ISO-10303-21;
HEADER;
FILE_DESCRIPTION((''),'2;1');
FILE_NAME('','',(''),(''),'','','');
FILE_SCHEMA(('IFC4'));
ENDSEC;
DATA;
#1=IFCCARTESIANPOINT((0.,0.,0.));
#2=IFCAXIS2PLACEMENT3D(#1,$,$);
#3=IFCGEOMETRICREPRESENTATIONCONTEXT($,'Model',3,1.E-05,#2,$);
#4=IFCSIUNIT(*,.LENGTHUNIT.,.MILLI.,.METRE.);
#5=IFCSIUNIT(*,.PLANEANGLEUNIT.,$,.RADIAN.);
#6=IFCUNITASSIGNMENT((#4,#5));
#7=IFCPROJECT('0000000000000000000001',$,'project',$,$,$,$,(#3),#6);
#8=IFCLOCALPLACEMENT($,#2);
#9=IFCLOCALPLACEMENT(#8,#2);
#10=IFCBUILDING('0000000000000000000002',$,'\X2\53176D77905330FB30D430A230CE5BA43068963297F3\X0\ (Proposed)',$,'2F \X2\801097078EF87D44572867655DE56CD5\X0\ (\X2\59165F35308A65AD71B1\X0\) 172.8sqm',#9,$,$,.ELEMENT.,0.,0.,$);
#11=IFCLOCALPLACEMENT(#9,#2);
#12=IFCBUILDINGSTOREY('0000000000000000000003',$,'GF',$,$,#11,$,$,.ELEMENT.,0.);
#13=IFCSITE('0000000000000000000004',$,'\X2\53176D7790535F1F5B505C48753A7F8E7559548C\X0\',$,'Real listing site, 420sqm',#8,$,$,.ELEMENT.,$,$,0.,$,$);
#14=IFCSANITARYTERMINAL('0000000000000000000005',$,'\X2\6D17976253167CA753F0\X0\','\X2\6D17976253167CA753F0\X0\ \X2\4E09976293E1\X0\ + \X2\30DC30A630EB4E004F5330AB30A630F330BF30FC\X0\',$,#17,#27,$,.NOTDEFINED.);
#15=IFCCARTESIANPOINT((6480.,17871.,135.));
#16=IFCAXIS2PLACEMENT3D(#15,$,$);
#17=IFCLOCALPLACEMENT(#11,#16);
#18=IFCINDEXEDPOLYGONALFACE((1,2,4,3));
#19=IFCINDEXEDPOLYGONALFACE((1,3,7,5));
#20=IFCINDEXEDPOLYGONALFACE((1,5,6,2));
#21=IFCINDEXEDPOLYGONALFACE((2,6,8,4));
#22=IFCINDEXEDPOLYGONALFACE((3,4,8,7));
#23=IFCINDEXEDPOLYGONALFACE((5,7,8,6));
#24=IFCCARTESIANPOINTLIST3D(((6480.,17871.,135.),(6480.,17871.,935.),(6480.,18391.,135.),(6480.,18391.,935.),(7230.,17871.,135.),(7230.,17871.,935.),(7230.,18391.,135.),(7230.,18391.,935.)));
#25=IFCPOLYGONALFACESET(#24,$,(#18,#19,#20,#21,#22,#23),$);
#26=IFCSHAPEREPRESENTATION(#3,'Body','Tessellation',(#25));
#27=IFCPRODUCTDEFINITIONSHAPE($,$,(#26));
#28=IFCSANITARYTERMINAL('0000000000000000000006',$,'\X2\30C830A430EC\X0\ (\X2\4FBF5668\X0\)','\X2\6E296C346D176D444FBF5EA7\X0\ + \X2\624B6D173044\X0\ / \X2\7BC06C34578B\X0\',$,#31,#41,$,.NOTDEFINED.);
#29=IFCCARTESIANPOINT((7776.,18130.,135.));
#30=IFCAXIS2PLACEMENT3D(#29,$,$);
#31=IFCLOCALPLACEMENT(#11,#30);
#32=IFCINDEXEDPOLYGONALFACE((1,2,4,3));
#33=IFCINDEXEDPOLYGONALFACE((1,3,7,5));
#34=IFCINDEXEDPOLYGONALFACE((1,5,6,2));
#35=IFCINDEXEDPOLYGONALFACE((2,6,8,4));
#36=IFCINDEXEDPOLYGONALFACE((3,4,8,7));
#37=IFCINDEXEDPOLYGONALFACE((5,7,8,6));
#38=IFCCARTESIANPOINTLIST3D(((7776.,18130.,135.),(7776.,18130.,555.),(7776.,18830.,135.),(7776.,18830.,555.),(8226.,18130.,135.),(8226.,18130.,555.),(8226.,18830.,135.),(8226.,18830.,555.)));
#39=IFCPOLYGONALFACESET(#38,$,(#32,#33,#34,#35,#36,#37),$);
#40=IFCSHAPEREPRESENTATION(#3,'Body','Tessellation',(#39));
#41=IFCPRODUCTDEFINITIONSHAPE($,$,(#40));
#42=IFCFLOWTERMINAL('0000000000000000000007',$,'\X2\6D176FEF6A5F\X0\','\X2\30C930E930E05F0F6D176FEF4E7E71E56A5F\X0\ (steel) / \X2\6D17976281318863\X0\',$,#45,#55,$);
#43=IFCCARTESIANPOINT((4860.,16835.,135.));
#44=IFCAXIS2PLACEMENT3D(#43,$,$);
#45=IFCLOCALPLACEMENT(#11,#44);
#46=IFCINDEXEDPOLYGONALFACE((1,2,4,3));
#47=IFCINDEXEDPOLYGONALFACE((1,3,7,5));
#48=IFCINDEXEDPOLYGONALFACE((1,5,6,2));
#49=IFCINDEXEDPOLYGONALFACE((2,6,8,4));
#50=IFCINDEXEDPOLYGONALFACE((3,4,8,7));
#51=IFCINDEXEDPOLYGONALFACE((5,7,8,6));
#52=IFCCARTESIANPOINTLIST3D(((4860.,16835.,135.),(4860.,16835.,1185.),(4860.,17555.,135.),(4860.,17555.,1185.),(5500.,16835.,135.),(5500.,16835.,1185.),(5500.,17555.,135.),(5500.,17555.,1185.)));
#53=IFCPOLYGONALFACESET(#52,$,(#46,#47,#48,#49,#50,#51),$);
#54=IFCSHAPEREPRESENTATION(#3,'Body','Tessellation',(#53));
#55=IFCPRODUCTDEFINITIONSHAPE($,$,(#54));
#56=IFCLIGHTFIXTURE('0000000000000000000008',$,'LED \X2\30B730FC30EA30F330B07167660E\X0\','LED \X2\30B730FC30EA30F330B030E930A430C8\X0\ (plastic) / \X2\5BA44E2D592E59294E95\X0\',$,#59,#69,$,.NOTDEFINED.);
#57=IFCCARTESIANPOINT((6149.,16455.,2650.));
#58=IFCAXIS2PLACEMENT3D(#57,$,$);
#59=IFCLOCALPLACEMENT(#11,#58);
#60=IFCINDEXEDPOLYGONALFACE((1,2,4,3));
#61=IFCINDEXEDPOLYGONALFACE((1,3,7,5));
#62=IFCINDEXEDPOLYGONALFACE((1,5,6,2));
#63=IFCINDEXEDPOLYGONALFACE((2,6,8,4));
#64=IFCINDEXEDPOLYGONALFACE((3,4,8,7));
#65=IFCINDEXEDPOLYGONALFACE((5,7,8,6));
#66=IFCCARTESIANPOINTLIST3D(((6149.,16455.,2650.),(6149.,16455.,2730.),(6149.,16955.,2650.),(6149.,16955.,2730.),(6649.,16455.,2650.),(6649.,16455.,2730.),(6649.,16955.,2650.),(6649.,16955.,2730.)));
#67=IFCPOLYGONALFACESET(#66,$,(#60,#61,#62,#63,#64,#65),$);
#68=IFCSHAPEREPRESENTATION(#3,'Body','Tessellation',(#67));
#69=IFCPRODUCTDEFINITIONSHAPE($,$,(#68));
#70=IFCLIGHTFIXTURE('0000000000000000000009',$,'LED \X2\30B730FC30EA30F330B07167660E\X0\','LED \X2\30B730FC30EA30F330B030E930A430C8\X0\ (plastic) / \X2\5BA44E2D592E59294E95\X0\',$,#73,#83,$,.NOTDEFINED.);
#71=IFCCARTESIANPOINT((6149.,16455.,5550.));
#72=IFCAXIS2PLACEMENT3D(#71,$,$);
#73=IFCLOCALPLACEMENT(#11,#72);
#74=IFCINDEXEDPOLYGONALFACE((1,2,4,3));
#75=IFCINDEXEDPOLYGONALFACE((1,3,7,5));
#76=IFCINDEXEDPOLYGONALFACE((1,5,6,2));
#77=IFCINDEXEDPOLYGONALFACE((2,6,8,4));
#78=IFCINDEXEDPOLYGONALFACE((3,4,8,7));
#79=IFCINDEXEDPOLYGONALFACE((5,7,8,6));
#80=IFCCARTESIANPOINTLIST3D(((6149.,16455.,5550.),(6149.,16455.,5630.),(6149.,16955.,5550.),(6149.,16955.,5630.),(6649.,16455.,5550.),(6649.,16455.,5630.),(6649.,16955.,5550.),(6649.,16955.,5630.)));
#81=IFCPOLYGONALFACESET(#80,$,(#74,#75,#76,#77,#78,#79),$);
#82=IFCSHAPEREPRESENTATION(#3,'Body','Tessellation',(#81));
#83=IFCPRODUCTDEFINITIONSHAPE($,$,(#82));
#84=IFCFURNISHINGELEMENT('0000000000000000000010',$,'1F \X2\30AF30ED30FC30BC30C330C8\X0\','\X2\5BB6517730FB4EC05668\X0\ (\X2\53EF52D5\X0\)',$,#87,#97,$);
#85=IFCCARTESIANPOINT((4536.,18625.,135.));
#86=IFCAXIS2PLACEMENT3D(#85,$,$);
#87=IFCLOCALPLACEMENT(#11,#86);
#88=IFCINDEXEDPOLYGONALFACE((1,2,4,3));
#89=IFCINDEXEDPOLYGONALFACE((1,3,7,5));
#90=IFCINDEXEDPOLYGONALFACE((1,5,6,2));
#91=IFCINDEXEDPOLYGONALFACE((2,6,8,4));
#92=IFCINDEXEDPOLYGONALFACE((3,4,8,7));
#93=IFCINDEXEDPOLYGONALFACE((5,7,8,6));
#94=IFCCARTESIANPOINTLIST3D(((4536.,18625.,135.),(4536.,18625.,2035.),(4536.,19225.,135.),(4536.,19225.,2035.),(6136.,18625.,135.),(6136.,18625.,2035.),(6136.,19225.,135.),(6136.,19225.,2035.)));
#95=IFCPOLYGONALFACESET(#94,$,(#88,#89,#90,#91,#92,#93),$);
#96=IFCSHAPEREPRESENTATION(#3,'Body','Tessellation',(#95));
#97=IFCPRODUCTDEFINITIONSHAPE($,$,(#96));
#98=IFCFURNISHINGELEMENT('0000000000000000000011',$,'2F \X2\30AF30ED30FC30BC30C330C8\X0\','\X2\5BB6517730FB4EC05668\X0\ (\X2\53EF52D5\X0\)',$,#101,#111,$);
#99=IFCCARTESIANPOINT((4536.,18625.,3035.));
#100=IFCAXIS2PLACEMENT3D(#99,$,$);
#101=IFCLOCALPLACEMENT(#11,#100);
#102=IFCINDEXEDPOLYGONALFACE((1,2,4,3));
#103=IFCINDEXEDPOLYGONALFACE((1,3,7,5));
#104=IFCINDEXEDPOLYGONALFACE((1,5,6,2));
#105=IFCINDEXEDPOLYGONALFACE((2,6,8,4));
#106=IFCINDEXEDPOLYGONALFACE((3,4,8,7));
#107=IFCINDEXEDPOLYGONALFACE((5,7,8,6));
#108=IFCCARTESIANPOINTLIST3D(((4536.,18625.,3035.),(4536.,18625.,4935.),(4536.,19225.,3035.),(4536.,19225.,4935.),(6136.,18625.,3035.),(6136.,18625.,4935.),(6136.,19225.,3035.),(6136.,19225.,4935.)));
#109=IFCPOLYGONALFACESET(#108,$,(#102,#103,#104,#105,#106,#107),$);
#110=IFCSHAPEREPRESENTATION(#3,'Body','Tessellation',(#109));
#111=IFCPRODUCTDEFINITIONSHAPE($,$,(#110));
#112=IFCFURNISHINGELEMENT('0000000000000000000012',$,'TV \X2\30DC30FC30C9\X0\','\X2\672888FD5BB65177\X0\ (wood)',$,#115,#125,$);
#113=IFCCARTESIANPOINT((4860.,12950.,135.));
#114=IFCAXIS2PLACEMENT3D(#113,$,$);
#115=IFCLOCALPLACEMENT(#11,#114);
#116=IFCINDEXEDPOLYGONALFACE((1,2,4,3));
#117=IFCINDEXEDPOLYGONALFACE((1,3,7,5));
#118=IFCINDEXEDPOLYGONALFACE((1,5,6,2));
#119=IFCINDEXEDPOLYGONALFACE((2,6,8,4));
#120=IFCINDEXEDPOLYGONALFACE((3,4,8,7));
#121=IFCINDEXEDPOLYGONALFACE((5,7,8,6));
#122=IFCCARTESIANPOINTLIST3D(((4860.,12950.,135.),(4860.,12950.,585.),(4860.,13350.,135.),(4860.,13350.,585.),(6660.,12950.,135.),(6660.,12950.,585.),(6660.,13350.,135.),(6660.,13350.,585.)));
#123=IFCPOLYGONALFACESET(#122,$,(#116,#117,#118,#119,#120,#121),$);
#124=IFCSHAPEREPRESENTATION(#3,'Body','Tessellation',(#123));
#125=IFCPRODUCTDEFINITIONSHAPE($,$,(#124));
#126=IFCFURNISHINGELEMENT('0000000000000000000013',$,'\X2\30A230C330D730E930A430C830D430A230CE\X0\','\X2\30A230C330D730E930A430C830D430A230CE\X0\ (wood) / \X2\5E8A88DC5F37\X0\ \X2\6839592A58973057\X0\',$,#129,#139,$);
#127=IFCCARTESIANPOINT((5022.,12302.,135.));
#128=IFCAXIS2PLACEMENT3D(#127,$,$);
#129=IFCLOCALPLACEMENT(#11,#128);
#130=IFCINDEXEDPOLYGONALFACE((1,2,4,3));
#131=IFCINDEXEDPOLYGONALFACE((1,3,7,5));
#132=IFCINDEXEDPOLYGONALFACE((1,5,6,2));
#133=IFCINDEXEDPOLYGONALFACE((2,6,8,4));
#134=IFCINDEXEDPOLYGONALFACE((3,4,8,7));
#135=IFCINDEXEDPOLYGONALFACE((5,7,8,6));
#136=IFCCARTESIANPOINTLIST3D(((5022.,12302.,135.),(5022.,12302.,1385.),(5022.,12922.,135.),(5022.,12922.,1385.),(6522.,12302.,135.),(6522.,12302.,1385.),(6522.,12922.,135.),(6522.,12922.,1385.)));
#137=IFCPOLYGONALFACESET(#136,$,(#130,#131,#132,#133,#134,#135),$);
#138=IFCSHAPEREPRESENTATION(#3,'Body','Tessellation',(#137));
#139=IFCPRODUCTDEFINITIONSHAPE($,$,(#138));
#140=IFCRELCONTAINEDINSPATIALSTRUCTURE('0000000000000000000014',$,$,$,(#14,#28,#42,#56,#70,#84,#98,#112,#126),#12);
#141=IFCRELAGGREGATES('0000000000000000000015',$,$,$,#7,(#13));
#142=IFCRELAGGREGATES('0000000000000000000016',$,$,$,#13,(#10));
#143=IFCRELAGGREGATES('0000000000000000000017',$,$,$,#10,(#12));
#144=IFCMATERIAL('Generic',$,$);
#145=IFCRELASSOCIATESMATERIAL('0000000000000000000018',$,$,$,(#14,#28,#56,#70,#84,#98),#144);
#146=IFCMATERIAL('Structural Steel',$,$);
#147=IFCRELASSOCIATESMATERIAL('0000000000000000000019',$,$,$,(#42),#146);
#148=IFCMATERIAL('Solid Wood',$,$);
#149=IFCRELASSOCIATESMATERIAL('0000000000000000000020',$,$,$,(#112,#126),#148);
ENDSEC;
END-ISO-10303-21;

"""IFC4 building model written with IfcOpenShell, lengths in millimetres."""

from ifc_helpers import new_model, si_unit, frame, frame_2d, origin, place, context, project, spatial, rectangle, extrude, material, element, save


model = new_model("IFC4")

# Units and contexts
model_context = context("Model", 3, precision=1e-05, world=origin())
ifc_project = project(units=[si_unit("LENGTHUNIT", "METRE", prefix="MILLI"), si_unit("PLANEANGLEUNIT", "RADIAN")], contexts=[model_context])

# Site, building, storey
site_placement = place(None, origin())
site = spatial("IfcSite", under=ifc_project, at=site_placement, Name="北海道弟子屈町美留和", ObjectType="Real listing site, 420sqm", CompositionType="ELEMENT", RefElevation=0.0)
building_placement = place(site_placement, origin())
building = spatial("IfcBuilding", under=site, at=building_placement, Name="北海道・ピアノ室と防音 (Proposed)", ObjectType="2F 耐震軸組在来工法 (外張り断熱) 172.8sqm", CompositionType="ELEMENT", ElevationOfRefHeight=0.0, ElevationOfTerrain=0.0)
storey_placement = place(building_placement, origin())
storey = spatial("IfcBuildingStorey", under=building, at=storey_placement, Name="GF", CompositionType="ELEMENT", Elevation=0.0)

# Shared definitions
ifc_material_1 = material(Name="Solid Wood")

# Sanitary terminals
ifc_material_2 = material(Name="Generic")
sanitary_terminal_1_placement = place(storey_placement, frame((6480.0, 17871.0, 135.0)))
element("IfcSanitaryTerminal", 1, at=sanitary_terminal_1_placement, inside=storey, material=ifc_material_2, Name="洗面化粧台", Description="洗面化粧台 三面鏡 + ボウル一体カウンター", PredefinedType="NOTDEFINED", context=model_context, shape_type="SweptSolid", body=[
    extrude(rectangle(XDim=750.0, YDim=520.0, at=frame_2d((375.0, 260.0))), frame((6480.0, 17871.0, 135.0)), (0.0, 0.0, 1.0), 800.0),
])
sanitary_terminal_2_placement = place(storey_placement, frame((7776.0, 18130.0, 135.0)))
element("IfcSanitaryTerminal", 2, at=sanitary_terminal_2_placement, inside=storey, material=ifc_material_2, Name="トイレ (便器)", Description="温水洗浄便座 + 手洗い / 節水型", PredefinedType="NOTDEFINED", context=model_context, shape_type="SweptSolid", body=[
    extrude(rectangle(XDim=450.0, YDim=700.0, at=frame_2d((225.0, 350.0))), frame((7776.0, 18130.0, 135.0)), (0.0, 0.0, 1.0), 420.0),
])

# Flow terminal
ifc_material_3 = material(Name="Structural Steel")
flow_terminal_placement = place(storey_placement, frame((4860.0, 16835.0, 135.0)))
element("IfcFlowTerminal", 3, at=flow_terminal_placement, inside=storey, material=ifc_material_3, Name="洗濯機", Description="ドラム式洗濯乾燥機 (steel) / 洗面脱衣", context=model_context, shape_type="SweptSolid", body=[
    extrude(rectangle(XDim=640.0, YDim=720.0, at=frame_2d((320.0, 360.0))), frame((4860.0, 16835.0, 135.0)), (0.0, 0.0, 1.0), 1050.0),
])

# Light fixtures
light_fixture_1_placement = place(storey_placement, frame((6149.0, 16455.0, 2650.0)))
element("IfcLightFixture", 4, at=light_fixture_1_placement, inside=storey, material=ifc_material_2, Name="LED シーリング照明", Description="LED シーリングライト (plastic) / 室中央天井", PredefinedType="NOTDEFINED", context=model_context, shape_type="SweptSolid", body=[
    extrude(rectangle(XDim=500.0, YDim=500.0, at=frame_2d((250.0, 250.0))), frame((6149.0, 16455.0, 2650.0)), (0.0, 0.0, 1.0), 80.0),
])
light_fixture_2_placement = place(storey_placement, frame((6149.0, 16455.0, 5550.0)))
element("IfcLightFixture", 5, at=light_fixture_2_placement, inside=storey, material=ifc_material_2, Name="LED シーリング照明", Description="LED シーリングライト (plastic) / 室中央天井", PredefinedType="NOTDEFINED", context=model_context, shape_type="SweptSolid", body=[
    extrude(rectangle(XDim=500.0, YDim=500.0, at=frame_2d((250.0, 250.0))), frame((6149.0, 16455.0, 5550.0)), (0.0, 0.0, 1.0), 80.0),
])

# Furnishing elements
furnishing_1_placement = place(storey_placement, frame((4536.0, 18625.0, 135.0)))
element("IfcFurnishingElement", 6, at=furnishing_1_placement, inside=storey, material=ifc_material_2, Name="1F クローゼット", Description="家具・什器 (可動)", context=model_context, shape_type="SweptSolid", body=[
    extrude(rectangle(XDim=1600.0, YDim=600.0, at=frame_2d((800.0, 300.0))), frame((4536.0, 18625.0, 135.0)), (0.0, 0.0, 1.0), 1900.0),
])
furnishing_2_placement = place(storey_placement, frame((4536.0, 18625.0, 3035.0)))
element("IfcFurnishingElement", 7, at=furnishing_2_placement, inside=storey, material=ifc_material_2, Name="2F クローゼット", Description="家具・什器 (可動)", context=model_context, shape_type="SweptSolid", body=[
    extrude(rectangle(XDim=1600.0, YDim=600.0, at=frame_2d((800.0, 300.0))), frame((4536.0, 18625.0, 3035.0)), (0.0, 0.0, 1.0), 1900.0),
])
furnishing_3_placement = place(storey_placement, frame((4860.0, 12950.0, 135.0)))
element("IfcFurnishingElement", 8, at=furnishing_3_placement, inside=storey, material=ifc_material_1, Name="TV ボード", Description="木製家具 (wood)", context=model_context, shape_type="SweptSolid", body=[
    extrude(rectangle(XDim=1800.0, YDim=400.0, at=frame_2d((900.0, 200.0))), frame((4860.0, 12950.0, 135.0)), (0.0, 0.0, 1.0), 450.0),
])
furnishing_4_placement = place(storey_placement, frame((5022.0, 12302.0, 135.0)))
element("IfcFurnishingElement", 9, at=furnishing_4_placement, inside=storey, material=ifc_material_1, Name="アップライトピアノ", Description="アップライトピアノ (wood) / 床補強 根太増し", context=model_context, shape_type="SweptSolid", body=[
    extrude(rectangle(XDim=1500.0, YDim=620.0, at=frame_2d((750.0, 310.0))), frame((5022.0, 12302.0, 135.0)), (0.0, 0.0, 1.0), 1250.0),
])

save(model, "model.ifc")
